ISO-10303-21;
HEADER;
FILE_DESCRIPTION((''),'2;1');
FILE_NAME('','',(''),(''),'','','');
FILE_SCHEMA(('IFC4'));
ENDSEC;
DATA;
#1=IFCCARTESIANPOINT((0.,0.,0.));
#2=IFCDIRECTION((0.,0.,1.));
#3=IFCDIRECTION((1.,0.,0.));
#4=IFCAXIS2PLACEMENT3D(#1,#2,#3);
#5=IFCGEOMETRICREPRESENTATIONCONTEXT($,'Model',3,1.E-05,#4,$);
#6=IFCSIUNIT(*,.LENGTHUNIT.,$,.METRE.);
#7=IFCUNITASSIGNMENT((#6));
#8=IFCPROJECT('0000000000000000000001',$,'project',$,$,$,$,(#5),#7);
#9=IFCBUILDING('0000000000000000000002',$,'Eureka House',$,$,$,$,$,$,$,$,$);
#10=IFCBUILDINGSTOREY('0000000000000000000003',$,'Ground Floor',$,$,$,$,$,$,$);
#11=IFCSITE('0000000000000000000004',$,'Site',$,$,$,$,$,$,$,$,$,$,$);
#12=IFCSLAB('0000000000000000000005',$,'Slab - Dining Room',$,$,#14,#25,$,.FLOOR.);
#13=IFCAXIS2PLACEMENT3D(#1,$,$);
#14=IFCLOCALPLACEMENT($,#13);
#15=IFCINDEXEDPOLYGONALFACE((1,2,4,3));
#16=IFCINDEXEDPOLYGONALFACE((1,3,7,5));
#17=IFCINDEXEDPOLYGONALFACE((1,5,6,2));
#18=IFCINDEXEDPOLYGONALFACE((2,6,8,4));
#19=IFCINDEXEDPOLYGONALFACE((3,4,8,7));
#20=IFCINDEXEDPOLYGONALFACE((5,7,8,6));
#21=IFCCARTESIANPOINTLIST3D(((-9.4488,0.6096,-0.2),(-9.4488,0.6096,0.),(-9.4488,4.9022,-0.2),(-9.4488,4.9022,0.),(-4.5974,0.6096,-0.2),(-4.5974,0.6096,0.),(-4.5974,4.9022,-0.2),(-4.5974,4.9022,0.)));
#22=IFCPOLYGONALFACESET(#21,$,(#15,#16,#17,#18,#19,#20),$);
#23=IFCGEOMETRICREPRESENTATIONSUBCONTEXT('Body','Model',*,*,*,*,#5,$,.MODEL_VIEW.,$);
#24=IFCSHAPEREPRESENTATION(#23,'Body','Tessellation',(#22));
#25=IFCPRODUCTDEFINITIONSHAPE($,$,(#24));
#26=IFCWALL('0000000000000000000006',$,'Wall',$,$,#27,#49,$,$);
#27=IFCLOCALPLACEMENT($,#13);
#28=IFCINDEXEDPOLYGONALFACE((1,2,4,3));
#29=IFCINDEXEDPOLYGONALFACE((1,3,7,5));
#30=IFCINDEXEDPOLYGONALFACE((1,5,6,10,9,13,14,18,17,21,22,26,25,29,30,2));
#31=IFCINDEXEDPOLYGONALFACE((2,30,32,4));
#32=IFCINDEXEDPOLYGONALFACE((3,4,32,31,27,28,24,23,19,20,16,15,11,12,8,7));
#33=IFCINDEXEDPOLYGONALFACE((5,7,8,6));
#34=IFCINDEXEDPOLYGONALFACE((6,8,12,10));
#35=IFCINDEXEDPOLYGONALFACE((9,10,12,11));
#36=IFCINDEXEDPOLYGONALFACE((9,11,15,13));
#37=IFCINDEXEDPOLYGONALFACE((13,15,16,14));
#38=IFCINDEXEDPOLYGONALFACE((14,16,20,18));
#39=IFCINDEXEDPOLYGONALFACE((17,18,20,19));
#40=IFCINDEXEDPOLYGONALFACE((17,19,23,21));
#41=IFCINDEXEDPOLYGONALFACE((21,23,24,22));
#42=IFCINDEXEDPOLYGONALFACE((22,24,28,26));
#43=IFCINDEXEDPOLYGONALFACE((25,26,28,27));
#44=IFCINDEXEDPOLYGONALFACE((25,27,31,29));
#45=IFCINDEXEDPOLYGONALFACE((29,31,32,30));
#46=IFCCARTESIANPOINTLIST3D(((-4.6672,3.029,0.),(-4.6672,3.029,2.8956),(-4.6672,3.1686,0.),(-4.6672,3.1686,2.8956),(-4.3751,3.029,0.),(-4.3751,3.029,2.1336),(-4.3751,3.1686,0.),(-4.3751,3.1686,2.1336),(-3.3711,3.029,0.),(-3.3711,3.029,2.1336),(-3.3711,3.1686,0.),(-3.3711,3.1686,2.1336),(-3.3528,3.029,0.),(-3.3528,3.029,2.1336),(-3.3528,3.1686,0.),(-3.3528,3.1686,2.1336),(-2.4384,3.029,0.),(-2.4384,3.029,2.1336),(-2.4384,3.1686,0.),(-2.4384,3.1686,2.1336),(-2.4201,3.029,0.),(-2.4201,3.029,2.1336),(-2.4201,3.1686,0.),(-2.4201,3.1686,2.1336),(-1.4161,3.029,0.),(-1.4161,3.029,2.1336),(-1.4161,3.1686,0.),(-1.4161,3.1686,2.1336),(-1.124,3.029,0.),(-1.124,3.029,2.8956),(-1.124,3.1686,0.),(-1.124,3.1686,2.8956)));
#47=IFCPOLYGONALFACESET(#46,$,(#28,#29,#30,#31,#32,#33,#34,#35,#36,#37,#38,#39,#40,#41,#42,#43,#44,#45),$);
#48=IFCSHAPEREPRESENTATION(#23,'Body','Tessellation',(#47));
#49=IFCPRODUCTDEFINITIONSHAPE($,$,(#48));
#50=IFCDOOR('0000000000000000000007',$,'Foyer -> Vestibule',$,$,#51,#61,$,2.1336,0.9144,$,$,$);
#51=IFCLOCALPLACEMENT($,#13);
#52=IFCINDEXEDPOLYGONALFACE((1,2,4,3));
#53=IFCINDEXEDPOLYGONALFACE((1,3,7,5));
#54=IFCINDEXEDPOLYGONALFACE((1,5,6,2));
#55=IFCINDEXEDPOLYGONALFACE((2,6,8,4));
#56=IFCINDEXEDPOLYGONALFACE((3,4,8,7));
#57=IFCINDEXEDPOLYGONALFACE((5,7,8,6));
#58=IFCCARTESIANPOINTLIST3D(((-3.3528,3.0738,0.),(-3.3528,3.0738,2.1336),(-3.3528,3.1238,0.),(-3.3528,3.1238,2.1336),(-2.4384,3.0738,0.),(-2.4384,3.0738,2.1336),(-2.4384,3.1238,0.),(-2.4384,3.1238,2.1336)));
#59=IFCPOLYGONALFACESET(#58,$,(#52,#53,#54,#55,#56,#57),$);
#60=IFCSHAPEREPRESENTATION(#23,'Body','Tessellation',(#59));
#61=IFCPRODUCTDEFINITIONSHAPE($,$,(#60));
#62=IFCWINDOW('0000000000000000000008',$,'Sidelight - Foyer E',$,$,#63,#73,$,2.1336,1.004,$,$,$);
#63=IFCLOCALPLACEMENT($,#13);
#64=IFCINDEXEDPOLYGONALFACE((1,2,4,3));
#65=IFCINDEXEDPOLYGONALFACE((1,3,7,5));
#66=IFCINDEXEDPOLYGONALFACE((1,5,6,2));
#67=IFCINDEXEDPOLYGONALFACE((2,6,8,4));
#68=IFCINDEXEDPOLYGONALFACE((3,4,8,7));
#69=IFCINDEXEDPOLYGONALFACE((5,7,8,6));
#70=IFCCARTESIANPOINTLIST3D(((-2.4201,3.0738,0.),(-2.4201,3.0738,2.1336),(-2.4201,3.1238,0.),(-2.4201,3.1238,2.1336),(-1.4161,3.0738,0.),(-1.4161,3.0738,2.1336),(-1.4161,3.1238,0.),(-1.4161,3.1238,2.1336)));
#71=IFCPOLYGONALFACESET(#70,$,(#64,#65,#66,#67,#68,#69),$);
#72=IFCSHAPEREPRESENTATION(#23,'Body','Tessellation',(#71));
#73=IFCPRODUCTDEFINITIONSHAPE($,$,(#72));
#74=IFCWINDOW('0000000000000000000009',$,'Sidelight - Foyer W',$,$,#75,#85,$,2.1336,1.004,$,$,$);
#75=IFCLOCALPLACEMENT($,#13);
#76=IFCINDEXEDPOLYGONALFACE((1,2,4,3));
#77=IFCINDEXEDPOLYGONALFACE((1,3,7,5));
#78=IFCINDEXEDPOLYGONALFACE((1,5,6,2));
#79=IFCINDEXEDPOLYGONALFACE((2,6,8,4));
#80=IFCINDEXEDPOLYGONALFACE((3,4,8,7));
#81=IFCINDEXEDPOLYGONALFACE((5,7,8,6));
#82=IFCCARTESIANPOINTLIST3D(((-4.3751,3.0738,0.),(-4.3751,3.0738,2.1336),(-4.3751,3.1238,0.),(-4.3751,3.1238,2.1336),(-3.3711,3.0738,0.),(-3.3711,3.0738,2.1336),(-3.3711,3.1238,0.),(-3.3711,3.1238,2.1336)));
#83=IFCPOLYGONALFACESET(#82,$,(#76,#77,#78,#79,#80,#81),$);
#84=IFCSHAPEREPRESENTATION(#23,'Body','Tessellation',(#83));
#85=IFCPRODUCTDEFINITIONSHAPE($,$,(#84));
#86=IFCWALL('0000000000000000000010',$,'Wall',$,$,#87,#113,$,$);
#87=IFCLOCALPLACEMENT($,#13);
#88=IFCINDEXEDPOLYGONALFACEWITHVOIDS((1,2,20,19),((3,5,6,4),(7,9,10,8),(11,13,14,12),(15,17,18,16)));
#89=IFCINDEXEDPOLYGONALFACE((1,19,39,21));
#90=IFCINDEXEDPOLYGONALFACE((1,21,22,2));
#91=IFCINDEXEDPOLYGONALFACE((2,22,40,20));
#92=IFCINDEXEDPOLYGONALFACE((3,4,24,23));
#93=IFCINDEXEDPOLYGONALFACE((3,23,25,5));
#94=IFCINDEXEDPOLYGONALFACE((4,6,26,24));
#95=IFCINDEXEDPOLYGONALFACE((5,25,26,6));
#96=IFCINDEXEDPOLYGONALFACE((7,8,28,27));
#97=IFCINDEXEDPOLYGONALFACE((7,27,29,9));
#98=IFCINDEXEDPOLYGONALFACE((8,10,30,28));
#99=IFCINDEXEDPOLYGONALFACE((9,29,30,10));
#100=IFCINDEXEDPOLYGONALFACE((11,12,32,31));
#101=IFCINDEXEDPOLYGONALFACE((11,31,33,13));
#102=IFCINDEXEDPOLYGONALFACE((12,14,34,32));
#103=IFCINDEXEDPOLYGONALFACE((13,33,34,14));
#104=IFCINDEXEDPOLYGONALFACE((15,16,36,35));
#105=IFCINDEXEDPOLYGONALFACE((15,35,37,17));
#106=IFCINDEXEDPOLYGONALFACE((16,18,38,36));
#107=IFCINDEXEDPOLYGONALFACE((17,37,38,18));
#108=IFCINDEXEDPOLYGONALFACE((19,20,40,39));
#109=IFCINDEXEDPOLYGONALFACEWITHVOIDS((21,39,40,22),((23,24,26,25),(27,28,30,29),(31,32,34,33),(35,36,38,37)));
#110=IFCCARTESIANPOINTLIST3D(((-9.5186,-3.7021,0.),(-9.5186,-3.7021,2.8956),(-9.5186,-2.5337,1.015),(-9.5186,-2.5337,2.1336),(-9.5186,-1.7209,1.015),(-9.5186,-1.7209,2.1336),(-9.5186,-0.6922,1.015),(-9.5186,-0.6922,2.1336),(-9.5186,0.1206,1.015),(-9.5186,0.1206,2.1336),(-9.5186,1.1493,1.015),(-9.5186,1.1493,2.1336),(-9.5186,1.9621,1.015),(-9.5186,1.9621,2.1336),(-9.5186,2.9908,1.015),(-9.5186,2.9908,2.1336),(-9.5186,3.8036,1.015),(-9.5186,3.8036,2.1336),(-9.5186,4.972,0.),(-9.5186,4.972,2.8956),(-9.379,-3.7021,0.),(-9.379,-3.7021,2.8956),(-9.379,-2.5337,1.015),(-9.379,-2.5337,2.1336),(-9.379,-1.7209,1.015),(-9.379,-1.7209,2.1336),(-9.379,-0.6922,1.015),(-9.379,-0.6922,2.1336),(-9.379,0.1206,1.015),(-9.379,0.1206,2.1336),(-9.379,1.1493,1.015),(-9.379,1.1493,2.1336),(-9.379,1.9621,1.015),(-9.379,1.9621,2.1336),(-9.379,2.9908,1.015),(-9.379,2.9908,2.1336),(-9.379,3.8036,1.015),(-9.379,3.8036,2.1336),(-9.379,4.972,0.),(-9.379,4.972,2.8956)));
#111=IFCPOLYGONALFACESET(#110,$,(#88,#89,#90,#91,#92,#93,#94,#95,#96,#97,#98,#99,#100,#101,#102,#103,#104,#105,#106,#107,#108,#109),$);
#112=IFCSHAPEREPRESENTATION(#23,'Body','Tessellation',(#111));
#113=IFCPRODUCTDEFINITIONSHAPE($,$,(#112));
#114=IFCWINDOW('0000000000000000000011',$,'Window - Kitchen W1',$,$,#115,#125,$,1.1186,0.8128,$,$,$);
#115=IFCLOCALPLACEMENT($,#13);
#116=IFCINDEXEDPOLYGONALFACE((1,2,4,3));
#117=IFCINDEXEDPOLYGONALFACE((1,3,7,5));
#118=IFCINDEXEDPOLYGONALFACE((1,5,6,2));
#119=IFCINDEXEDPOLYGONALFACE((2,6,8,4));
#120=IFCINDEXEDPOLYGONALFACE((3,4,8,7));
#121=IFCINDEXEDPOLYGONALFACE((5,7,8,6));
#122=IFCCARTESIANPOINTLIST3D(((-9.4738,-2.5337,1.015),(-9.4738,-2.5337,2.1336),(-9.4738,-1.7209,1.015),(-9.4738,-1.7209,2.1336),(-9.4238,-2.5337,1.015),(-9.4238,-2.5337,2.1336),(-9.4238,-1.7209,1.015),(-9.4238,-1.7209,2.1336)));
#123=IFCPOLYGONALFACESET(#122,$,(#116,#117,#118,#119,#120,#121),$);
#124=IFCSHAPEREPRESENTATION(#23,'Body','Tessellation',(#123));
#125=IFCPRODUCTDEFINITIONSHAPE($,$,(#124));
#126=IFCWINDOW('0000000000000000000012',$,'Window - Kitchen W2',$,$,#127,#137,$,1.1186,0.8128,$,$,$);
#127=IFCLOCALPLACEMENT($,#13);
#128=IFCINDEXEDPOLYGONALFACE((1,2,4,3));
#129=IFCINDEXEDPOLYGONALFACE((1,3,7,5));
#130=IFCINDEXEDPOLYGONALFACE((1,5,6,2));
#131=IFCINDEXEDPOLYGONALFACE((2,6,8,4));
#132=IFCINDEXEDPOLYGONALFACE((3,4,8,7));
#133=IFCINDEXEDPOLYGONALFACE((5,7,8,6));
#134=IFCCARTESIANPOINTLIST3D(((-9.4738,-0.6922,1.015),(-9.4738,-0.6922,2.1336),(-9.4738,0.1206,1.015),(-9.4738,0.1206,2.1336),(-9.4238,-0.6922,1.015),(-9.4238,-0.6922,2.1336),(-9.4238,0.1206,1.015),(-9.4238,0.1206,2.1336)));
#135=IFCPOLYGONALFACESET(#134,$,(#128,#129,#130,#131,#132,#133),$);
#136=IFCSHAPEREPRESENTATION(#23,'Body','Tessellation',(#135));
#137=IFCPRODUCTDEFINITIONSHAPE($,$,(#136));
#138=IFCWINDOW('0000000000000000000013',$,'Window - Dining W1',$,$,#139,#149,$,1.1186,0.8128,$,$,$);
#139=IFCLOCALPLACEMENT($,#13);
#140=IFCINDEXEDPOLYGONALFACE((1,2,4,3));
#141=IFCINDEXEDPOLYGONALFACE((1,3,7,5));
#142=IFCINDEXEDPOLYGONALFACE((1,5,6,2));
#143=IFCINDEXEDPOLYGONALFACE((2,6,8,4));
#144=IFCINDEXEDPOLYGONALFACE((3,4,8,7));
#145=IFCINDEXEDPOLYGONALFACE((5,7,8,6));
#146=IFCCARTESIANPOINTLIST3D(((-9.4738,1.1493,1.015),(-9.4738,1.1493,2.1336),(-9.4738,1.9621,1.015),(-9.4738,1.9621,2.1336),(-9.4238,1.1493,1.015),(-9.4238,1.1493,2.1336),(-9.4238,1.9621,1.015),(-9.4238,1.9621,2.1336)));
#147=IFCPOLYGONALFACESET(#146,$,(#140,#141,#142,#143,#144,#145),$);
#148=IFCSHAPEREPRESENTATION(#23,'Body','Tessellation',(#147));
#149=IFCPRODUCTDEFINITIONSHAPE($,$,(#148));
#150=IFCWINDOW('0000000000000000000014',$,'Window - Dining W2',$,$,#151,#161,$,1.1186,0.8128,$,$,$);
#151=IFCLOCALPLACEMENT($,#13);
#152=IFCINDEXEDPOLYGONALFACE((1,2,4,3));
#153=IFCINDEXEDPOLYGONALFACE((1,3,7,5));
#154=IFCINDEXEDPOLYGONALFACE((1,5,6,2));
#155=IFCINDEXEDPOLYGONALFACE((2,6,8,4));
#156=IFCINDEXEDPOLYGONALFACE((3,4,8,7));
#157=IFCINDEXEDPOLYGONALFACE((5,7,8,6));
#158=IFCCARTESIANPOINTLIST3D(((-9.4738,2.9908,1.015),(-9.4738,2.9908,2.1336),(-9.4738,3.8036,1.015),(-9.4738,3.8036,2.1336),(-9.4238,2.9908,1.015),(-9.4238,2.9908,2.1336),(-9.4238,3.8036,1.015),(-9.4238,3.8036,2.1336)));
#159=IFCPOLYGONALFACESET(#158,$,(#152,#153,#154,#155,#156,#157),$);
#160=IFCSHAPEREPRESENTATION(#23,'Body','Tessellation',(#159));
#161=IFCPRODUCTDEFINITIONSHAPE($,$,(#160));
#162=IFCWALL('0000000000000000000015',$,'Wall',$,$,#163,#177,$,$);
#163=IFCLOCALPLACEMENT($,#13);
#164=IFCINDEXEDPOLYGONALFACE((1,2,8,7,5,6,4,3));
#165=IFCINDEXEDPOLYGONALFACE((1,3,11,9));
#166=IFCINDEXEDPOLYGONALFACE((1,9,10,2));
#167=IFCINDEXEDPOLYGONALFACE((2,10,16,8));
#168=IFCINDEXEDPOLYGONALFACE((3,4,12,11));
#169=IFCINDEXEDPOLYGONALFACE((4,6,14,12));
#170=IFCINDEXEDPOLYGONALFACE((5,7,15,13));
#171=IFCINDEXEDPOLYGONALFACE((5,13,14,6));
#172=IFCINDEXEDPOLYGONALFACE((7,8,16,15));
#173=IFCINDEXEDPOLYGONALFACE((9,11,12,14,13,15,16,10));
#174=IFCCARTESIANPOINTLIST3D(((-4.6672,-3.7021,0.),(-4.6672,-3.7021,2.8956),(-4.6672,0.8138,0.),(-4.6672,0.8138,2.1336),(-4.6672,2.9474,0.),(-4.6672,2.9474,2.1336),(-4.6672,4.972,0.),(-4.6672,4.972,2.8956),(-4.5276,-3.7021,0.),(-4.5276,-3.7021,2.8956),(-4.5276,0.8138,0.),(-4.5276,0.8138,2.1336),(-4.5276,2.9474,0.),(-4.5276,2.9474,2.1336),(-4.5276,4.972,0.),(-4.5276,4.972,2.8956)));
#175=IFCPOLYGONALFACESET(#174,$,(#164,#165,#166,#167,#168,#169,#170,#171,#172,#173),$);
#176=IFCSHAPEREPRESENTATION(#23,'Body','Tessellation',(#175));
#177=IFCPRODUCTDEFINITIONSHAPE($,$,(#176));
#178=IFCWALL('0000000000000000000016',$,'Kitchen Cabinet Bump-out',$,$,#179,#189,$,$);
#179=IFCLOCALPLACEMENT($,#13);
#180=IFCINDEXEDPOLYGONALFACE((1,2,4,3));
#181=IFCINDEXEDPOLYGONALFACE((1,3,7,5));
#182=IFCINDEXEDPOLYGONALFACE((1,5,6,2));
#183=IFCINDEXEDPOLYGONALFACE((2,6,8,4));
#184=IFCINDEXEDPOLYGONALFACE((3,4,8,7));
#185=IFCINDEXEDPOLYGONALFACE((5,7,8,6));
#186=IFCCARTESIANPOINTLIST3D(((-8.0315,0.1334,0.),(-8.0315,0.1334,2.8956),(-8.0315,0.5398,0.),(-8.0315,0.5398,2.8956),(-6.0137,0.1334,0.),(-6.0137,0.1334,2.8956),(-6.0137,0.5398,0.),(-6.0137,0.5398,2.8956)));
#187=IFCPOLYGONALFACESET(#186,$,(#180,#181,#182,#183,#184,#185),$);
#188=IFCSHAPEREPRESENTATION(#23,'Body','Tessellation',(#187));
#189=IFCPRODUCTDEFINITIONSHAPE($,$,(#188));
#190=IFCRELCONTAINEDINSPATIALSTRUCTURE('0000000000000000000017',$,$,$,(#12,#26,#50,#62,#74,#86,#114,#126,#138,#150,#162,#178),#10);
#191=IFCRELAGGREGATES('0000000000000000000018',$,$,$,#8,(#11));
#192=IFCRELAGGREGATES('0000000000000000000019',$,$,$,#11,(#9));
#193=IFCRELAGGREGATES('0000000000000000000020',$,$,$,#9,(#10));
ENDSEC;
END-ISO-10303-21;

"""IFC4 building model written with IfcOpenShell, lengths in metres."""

from ifc_helpers import new_model, si_unit, frame, origin, origin_with_axes, origin_2d, place, context, subcontext, project, spatial, rectangle, extrude, element, fill, save


model = new_model("IFC4")

# Units and contexts
model_context = context("Model", 3, precision=1e-05, world=origin_with_axes())
body_context = subcontext(model_context, "Body", "Model", "MODEL_VIEW")
ifc_project = project(units=[si_unit("LENGTHUNIT", "METRE")], contexts=[model_context])

# Site, building, storey
site = spatial("IfcSite", under=ifc_project, Name="Site")
building = spatial("IfcBuilding", under=site, Name="Eureka House")
storey = spatial("IfcBuildingStorey", under=building, Name="Ground Floor")

# Slab
slab_placement = place(None, frame((-7.0231, 2.7559, -0.2), z_axis=(0.0, 0.0, 1.0), x_axis=(1.0, 0.0, 0.0)))
element("IfcSlab", 1, at=slab_placement, inside=storey, Name="Slab - Dining Room", PredefinedType="FLOOR", context=body_context, shape_type="SweptSolid", body=[
    extrude(rectangle(XDim=4.8514, YDim=4.2926, at=origin_2d()), origin(), (0.0, 0.0, 1.0), 0.2),
])

# Wall, openings, door, windows
wall_1_placement = place(None, frame((-2.8956, 3.0988, 0.0), z_axis=(0.0, 0.0, 1.0), x_axis=(1.0, 0.0, 0.0)))
wall_1 = element("IfcWall", 2, at=wall_1_placement, inside=storey, Name="Wall", context=body_context, shape_type="SweptSolid", body=[
    extrude(rectangle(XDim=3.5433, YDim=0.1397, at=origin_2d()), origin(), (0.0, 0.0, 1.0), 2.8956),
])
opening_1_placement = place(wall_1_placement, frame((0.0, 0.0, 0.0), z_axis=(0.0, 0.0, 1.0), x_axis=(1.0, 0.0, 0.0)))
opening_1 = element("IfcOpeningElement", 3, at=opening_1_placement, cuts=wall_1, context=body_context, shape_type="SweptSolid", body=[
    extrude(rectangle(XDim=0.9144, YDim=0.2397, at=origin_2d()), origin(), (0.0, 0.0, 1.0), 2.1336),
])
opening_2_placement = place(wall_1_placement, frame((0.9775, 0.0, 0.0), z_axis=(0.0, 0.0, 1.0), x_axis=(1.0, 0.0, 0.0)))
opening_2 = element("IfcOpeningElement", 4, at=opening_2_placement, cuts=wall_1, context=body_context, shape_type="SweptSolid", body=[
    extrude(rectangle(XDim=1.004, YDim=0.2397, at=origin_2d()), origin(), (0.0, 0.0, 1.0), 2.1336),
])
opening_3_placement = place(wall_1_placement, frame((-0.9775, 0.0, 0.0), z_axis=(0.0, 0.0, 1.0), x_axis=(1.0, 0.0, 0.0)))
opening_3 = element("IfcOpeningElement", 5, at=opening_3_placement, cuts=wall_1, context=body_context, shape_type="SweptSolid", body=[
    extrude(rectangle(XDim=1.004, YDim=0.2397, at=origin_2d()), origin(), (0.0, 0.0, 1.0), 2.1336),
])
door_placement = place(opening_1_placement, origin_with_axes())
door = element("IfcDoor", 6, at=door_placement, inside=storey, Name="Foyer -> Vestibule", OverallHeight=2.1336, OverallWidth=0.9144, context=body_context, shape_type="SweptSolid", body=[
    extrude(rectangle(XDim=0.9144, YDim=0.05, at=origin_2d()), origin(), (0.0, 0.0, 1.0), 2.1336),
])
fill(opening_1, door)
window_1_placement = place(opening_2_placement, origin_with_axes())
window_1 = element("IfcWindow", 7, at=window_1_placement, inside=storey, Name="Sidelight - Foyer E", OverallHeight=2.1336, OverallWidth=1.004, context=body_context, shape_type="SweptSolid", body=[
    extrude(rectangle(XDim=1.004, YDim=0.05, at=origin_2d()), origin(), (0.0, 0.0, 1.0), 2.1336),
])
fill(opening_2, window_1)
window_2_placement = place(opening_3_placement, origin_with_axes())
window_2 = element("IfcWindow", 8, at=window_2_placement, inside=storey, Name="Sidelight - Foyer W", OverallHeight=2.1336, OverallWidth=1.004, context=body_context, shape_type="SweptSolid", body=[
    extrude(rectangle(XDim=1.004, YDim=0.05, at=origin_2d()), origin(), (0.0, 0.0, 1.0), 2.1336),
])
fill(opening_3, window_2)

# Wall, openings, windows
wall_2_placement = place(None, frame((-9.4488, 0.635, 0.0), z_axis=(0.0, 0.0, 1.0), x_axis=(1.0, 0.0, 0.0)))
wall_2 = element("IfcWall", 9, at=wall_2_placement, inside=storey, Name="Wall", context=body_context, shape_type="SweptSolid", body=[
    extrude(rectangle(XDim=0.1397, YDim=8.6741, at=origin_2d()), origin(), (0.0, 0.0, 1.0), 2.8956),
])
opening_4_placement = place(wall_2_placement, frame((0.0, -2.7623, 1.015), z_axis=(0.0, 0.0, 1.0), x_axis=(1.0, 0.0, 0.0)))
opening_4 = element("IfcOpeningElement", 10, at=opening_4_placement, cuts=wall_2, context=body_context, shape_type="SweptSolid", body=[
    extrude(rectangle(XDim=0.2397, YDim=0.8128, at=origin_2d()), origin(), (0.0, 0.0, 1.0), 1.1186),
])
opening_5_placement = place(wall_2_placement, frame((0.0, -0.9208, 1.015), z_axis=(0.0, 0.0, 1.0), x_axis=(1.0, 0.0, 0.0)))
opening_5 = element("IfcOpeningElement", 11, at=opening_5_placement, cuts=wall_2, context=body_context, shape_type="SweptSolid", body=[
    extrude(rectangle(XDim=0.2397, YDim=0.8128, at=origin_2d()), origin(), (0.0, 0.0, 1.0), 1.1186),
])
opening_6_placement = place(wall_2_placement, frame((0.0, 0.9208, 1.015), z_axis=(0.0, 0.0, 1.0), x_axis=(1.0, 0.0, 0.0)))
opening_6 = element("IfcOpeningElement", 12, at=opening_6_placement, cuts=wall_2, context=body_context, shape_type="SweptSolid", body=[
    extrude(rectangle(XDim=0.2397, YDim=0.8128, at=origin_2d()), origin(), (0.0, 0.0, 1.0), 1.1186),
])
opening_7_placement = place(wall_2_placement, frame((0.0, 2.7623, 1.015), z_axis=(0.0, 0.0, 1.0), x_axis=(1.0, 0.0, 0.0)))
opening_7 = element("IfcOpeningElement", 13, at=opening_7_placement, cuts=wall_2, context=body_context, shape_type="SweptSolid", body=[
    extrude(rectangle(XDim=0.2397, YDim=0.8128, at=origin_2d()), origin(), (0.0, 0.0, 1.0), 1.1186),
])
window_3_placement = place(opening_4_placement, origin_with_axes())
window_3 = element("IfcWindow", 14, at=window_3_placement, inside=storey, Name="Window - Kitchen W1", OverallHeight=1.1186, OverallWidth=0.8128, context=body_context, shape_type="SweptSolid", body=[
    extrude(rectangle(XDim=0.05, YDim=0.8128, at=origin_2d()), origin(), (0.0, 0.0, 1.0), 1.1186),
])
fill(opening_4, window_3)
window_4_placement = place(opening_5_placement, frame((0.0, 0.0, 0.0), z_axis=(0.0, 0.0, 1.0), x_axis=(1.0, 0.0, 0.0)))
window_4 = element("IfcWindow", 15, at=window_4_placement, inside=storey, Name="Window - Kitchen W2", OverallHeight=1.1186, OverallWidth=0.8128, context=body_context, shape_type="SweptSolid", body=[
    extrude(rectangle(XDim=0.05, YDim=0.8128, at=origin_2d()), origin(), (0.0, 0.0, 1.0), 1.1186),
])
fill(opening_5, window_4)
window_5_placement = place(opening_6_placement, origin_with_axes())
window_5 = element("IfcWindow", 16, at=window_5_placement, inside=storey, Name="Window - Dining W1", OverallHeight=1.1186, OverallWidth=0.8128, context=body_context, shape_type="SweptSolid", body=[
    extrude(rectangle(XDim=0.05, YDim=0.8128, at=origin_2d()), origin(), (0.0, 0.0, 1.0), 1.1186),
])
fill(opening_6, window_5)
window_6_placement = place(opening_7_placement, origin_with_axes())
window_6 = element("IfcWindow", 17, at=window_6_placement, inside=storey, Name="Window - Dining W2", OverallHeight=1.1186, OverallWidth=0.8128, context=body_context, shape_type="SweptSolid", body=[
    extrude(rectangle(XDim=0.05, YDim=0.8128, at=origin_2d()), origin(), (0.0, 0.0, 1.0), 1.1186),
])
fill(opening_7, window_6)

# Wall, opening
wall_3_placement = place(None, frame((-4.5974, 0.635, 0.0), z_axis=(0.0, 0.0, 1.0), x_axis=(1.0, 0.0, 0.0)))
wall_3 = element("IfcWall", 18, at=wall_3_placement, inside=storey, Name="Wall", context=body_context, shape_type="SweptSolid", body=[
    extrude(rectangle(XDim=0.1397, YDim=8.6741, at=origin_2d()), origin(), (0.0, 0.0, 1.0), 2.8956),
])
opening_8_placement = place(wall_3_placement, frame((0.0, 1.2456, 0.0), z_axis=(0.0, 0.0, 1.0), x_axis=(1.0, 0.0, 0.0)))
element("IfcOpeningElement", 19, at=opening_8_placement, cuts=wall_3, context=body_context, shape_type="SweptSolid", body=[
    extrude(rectangle(XDim=0.2397, YDim=2.1336, at=origin_2d()), origin(), (0.0, 0.0, 1.0), 2.1336),
])

# Wall
wall_4_placement = place(None, frame((-7.0226, 0.3366, 0.0), z_axis=(0.0, 0.0, 1.0), x_axis=(1.0, 0.0, 0.0)))
element("IfcWall", 20, at=wall_4_placement, inside=storey, Name="Kitchen Cabinet Bump-out", context=body_context, shape_type="SweptSolid", body=[
    extrude(rectangle(XDim=2.0178, YDim=0.4064, at=origin_2d()), origin(), (0.0, 0.0, 1.0), 2.8956),
])

save(model, "model.ifc")
